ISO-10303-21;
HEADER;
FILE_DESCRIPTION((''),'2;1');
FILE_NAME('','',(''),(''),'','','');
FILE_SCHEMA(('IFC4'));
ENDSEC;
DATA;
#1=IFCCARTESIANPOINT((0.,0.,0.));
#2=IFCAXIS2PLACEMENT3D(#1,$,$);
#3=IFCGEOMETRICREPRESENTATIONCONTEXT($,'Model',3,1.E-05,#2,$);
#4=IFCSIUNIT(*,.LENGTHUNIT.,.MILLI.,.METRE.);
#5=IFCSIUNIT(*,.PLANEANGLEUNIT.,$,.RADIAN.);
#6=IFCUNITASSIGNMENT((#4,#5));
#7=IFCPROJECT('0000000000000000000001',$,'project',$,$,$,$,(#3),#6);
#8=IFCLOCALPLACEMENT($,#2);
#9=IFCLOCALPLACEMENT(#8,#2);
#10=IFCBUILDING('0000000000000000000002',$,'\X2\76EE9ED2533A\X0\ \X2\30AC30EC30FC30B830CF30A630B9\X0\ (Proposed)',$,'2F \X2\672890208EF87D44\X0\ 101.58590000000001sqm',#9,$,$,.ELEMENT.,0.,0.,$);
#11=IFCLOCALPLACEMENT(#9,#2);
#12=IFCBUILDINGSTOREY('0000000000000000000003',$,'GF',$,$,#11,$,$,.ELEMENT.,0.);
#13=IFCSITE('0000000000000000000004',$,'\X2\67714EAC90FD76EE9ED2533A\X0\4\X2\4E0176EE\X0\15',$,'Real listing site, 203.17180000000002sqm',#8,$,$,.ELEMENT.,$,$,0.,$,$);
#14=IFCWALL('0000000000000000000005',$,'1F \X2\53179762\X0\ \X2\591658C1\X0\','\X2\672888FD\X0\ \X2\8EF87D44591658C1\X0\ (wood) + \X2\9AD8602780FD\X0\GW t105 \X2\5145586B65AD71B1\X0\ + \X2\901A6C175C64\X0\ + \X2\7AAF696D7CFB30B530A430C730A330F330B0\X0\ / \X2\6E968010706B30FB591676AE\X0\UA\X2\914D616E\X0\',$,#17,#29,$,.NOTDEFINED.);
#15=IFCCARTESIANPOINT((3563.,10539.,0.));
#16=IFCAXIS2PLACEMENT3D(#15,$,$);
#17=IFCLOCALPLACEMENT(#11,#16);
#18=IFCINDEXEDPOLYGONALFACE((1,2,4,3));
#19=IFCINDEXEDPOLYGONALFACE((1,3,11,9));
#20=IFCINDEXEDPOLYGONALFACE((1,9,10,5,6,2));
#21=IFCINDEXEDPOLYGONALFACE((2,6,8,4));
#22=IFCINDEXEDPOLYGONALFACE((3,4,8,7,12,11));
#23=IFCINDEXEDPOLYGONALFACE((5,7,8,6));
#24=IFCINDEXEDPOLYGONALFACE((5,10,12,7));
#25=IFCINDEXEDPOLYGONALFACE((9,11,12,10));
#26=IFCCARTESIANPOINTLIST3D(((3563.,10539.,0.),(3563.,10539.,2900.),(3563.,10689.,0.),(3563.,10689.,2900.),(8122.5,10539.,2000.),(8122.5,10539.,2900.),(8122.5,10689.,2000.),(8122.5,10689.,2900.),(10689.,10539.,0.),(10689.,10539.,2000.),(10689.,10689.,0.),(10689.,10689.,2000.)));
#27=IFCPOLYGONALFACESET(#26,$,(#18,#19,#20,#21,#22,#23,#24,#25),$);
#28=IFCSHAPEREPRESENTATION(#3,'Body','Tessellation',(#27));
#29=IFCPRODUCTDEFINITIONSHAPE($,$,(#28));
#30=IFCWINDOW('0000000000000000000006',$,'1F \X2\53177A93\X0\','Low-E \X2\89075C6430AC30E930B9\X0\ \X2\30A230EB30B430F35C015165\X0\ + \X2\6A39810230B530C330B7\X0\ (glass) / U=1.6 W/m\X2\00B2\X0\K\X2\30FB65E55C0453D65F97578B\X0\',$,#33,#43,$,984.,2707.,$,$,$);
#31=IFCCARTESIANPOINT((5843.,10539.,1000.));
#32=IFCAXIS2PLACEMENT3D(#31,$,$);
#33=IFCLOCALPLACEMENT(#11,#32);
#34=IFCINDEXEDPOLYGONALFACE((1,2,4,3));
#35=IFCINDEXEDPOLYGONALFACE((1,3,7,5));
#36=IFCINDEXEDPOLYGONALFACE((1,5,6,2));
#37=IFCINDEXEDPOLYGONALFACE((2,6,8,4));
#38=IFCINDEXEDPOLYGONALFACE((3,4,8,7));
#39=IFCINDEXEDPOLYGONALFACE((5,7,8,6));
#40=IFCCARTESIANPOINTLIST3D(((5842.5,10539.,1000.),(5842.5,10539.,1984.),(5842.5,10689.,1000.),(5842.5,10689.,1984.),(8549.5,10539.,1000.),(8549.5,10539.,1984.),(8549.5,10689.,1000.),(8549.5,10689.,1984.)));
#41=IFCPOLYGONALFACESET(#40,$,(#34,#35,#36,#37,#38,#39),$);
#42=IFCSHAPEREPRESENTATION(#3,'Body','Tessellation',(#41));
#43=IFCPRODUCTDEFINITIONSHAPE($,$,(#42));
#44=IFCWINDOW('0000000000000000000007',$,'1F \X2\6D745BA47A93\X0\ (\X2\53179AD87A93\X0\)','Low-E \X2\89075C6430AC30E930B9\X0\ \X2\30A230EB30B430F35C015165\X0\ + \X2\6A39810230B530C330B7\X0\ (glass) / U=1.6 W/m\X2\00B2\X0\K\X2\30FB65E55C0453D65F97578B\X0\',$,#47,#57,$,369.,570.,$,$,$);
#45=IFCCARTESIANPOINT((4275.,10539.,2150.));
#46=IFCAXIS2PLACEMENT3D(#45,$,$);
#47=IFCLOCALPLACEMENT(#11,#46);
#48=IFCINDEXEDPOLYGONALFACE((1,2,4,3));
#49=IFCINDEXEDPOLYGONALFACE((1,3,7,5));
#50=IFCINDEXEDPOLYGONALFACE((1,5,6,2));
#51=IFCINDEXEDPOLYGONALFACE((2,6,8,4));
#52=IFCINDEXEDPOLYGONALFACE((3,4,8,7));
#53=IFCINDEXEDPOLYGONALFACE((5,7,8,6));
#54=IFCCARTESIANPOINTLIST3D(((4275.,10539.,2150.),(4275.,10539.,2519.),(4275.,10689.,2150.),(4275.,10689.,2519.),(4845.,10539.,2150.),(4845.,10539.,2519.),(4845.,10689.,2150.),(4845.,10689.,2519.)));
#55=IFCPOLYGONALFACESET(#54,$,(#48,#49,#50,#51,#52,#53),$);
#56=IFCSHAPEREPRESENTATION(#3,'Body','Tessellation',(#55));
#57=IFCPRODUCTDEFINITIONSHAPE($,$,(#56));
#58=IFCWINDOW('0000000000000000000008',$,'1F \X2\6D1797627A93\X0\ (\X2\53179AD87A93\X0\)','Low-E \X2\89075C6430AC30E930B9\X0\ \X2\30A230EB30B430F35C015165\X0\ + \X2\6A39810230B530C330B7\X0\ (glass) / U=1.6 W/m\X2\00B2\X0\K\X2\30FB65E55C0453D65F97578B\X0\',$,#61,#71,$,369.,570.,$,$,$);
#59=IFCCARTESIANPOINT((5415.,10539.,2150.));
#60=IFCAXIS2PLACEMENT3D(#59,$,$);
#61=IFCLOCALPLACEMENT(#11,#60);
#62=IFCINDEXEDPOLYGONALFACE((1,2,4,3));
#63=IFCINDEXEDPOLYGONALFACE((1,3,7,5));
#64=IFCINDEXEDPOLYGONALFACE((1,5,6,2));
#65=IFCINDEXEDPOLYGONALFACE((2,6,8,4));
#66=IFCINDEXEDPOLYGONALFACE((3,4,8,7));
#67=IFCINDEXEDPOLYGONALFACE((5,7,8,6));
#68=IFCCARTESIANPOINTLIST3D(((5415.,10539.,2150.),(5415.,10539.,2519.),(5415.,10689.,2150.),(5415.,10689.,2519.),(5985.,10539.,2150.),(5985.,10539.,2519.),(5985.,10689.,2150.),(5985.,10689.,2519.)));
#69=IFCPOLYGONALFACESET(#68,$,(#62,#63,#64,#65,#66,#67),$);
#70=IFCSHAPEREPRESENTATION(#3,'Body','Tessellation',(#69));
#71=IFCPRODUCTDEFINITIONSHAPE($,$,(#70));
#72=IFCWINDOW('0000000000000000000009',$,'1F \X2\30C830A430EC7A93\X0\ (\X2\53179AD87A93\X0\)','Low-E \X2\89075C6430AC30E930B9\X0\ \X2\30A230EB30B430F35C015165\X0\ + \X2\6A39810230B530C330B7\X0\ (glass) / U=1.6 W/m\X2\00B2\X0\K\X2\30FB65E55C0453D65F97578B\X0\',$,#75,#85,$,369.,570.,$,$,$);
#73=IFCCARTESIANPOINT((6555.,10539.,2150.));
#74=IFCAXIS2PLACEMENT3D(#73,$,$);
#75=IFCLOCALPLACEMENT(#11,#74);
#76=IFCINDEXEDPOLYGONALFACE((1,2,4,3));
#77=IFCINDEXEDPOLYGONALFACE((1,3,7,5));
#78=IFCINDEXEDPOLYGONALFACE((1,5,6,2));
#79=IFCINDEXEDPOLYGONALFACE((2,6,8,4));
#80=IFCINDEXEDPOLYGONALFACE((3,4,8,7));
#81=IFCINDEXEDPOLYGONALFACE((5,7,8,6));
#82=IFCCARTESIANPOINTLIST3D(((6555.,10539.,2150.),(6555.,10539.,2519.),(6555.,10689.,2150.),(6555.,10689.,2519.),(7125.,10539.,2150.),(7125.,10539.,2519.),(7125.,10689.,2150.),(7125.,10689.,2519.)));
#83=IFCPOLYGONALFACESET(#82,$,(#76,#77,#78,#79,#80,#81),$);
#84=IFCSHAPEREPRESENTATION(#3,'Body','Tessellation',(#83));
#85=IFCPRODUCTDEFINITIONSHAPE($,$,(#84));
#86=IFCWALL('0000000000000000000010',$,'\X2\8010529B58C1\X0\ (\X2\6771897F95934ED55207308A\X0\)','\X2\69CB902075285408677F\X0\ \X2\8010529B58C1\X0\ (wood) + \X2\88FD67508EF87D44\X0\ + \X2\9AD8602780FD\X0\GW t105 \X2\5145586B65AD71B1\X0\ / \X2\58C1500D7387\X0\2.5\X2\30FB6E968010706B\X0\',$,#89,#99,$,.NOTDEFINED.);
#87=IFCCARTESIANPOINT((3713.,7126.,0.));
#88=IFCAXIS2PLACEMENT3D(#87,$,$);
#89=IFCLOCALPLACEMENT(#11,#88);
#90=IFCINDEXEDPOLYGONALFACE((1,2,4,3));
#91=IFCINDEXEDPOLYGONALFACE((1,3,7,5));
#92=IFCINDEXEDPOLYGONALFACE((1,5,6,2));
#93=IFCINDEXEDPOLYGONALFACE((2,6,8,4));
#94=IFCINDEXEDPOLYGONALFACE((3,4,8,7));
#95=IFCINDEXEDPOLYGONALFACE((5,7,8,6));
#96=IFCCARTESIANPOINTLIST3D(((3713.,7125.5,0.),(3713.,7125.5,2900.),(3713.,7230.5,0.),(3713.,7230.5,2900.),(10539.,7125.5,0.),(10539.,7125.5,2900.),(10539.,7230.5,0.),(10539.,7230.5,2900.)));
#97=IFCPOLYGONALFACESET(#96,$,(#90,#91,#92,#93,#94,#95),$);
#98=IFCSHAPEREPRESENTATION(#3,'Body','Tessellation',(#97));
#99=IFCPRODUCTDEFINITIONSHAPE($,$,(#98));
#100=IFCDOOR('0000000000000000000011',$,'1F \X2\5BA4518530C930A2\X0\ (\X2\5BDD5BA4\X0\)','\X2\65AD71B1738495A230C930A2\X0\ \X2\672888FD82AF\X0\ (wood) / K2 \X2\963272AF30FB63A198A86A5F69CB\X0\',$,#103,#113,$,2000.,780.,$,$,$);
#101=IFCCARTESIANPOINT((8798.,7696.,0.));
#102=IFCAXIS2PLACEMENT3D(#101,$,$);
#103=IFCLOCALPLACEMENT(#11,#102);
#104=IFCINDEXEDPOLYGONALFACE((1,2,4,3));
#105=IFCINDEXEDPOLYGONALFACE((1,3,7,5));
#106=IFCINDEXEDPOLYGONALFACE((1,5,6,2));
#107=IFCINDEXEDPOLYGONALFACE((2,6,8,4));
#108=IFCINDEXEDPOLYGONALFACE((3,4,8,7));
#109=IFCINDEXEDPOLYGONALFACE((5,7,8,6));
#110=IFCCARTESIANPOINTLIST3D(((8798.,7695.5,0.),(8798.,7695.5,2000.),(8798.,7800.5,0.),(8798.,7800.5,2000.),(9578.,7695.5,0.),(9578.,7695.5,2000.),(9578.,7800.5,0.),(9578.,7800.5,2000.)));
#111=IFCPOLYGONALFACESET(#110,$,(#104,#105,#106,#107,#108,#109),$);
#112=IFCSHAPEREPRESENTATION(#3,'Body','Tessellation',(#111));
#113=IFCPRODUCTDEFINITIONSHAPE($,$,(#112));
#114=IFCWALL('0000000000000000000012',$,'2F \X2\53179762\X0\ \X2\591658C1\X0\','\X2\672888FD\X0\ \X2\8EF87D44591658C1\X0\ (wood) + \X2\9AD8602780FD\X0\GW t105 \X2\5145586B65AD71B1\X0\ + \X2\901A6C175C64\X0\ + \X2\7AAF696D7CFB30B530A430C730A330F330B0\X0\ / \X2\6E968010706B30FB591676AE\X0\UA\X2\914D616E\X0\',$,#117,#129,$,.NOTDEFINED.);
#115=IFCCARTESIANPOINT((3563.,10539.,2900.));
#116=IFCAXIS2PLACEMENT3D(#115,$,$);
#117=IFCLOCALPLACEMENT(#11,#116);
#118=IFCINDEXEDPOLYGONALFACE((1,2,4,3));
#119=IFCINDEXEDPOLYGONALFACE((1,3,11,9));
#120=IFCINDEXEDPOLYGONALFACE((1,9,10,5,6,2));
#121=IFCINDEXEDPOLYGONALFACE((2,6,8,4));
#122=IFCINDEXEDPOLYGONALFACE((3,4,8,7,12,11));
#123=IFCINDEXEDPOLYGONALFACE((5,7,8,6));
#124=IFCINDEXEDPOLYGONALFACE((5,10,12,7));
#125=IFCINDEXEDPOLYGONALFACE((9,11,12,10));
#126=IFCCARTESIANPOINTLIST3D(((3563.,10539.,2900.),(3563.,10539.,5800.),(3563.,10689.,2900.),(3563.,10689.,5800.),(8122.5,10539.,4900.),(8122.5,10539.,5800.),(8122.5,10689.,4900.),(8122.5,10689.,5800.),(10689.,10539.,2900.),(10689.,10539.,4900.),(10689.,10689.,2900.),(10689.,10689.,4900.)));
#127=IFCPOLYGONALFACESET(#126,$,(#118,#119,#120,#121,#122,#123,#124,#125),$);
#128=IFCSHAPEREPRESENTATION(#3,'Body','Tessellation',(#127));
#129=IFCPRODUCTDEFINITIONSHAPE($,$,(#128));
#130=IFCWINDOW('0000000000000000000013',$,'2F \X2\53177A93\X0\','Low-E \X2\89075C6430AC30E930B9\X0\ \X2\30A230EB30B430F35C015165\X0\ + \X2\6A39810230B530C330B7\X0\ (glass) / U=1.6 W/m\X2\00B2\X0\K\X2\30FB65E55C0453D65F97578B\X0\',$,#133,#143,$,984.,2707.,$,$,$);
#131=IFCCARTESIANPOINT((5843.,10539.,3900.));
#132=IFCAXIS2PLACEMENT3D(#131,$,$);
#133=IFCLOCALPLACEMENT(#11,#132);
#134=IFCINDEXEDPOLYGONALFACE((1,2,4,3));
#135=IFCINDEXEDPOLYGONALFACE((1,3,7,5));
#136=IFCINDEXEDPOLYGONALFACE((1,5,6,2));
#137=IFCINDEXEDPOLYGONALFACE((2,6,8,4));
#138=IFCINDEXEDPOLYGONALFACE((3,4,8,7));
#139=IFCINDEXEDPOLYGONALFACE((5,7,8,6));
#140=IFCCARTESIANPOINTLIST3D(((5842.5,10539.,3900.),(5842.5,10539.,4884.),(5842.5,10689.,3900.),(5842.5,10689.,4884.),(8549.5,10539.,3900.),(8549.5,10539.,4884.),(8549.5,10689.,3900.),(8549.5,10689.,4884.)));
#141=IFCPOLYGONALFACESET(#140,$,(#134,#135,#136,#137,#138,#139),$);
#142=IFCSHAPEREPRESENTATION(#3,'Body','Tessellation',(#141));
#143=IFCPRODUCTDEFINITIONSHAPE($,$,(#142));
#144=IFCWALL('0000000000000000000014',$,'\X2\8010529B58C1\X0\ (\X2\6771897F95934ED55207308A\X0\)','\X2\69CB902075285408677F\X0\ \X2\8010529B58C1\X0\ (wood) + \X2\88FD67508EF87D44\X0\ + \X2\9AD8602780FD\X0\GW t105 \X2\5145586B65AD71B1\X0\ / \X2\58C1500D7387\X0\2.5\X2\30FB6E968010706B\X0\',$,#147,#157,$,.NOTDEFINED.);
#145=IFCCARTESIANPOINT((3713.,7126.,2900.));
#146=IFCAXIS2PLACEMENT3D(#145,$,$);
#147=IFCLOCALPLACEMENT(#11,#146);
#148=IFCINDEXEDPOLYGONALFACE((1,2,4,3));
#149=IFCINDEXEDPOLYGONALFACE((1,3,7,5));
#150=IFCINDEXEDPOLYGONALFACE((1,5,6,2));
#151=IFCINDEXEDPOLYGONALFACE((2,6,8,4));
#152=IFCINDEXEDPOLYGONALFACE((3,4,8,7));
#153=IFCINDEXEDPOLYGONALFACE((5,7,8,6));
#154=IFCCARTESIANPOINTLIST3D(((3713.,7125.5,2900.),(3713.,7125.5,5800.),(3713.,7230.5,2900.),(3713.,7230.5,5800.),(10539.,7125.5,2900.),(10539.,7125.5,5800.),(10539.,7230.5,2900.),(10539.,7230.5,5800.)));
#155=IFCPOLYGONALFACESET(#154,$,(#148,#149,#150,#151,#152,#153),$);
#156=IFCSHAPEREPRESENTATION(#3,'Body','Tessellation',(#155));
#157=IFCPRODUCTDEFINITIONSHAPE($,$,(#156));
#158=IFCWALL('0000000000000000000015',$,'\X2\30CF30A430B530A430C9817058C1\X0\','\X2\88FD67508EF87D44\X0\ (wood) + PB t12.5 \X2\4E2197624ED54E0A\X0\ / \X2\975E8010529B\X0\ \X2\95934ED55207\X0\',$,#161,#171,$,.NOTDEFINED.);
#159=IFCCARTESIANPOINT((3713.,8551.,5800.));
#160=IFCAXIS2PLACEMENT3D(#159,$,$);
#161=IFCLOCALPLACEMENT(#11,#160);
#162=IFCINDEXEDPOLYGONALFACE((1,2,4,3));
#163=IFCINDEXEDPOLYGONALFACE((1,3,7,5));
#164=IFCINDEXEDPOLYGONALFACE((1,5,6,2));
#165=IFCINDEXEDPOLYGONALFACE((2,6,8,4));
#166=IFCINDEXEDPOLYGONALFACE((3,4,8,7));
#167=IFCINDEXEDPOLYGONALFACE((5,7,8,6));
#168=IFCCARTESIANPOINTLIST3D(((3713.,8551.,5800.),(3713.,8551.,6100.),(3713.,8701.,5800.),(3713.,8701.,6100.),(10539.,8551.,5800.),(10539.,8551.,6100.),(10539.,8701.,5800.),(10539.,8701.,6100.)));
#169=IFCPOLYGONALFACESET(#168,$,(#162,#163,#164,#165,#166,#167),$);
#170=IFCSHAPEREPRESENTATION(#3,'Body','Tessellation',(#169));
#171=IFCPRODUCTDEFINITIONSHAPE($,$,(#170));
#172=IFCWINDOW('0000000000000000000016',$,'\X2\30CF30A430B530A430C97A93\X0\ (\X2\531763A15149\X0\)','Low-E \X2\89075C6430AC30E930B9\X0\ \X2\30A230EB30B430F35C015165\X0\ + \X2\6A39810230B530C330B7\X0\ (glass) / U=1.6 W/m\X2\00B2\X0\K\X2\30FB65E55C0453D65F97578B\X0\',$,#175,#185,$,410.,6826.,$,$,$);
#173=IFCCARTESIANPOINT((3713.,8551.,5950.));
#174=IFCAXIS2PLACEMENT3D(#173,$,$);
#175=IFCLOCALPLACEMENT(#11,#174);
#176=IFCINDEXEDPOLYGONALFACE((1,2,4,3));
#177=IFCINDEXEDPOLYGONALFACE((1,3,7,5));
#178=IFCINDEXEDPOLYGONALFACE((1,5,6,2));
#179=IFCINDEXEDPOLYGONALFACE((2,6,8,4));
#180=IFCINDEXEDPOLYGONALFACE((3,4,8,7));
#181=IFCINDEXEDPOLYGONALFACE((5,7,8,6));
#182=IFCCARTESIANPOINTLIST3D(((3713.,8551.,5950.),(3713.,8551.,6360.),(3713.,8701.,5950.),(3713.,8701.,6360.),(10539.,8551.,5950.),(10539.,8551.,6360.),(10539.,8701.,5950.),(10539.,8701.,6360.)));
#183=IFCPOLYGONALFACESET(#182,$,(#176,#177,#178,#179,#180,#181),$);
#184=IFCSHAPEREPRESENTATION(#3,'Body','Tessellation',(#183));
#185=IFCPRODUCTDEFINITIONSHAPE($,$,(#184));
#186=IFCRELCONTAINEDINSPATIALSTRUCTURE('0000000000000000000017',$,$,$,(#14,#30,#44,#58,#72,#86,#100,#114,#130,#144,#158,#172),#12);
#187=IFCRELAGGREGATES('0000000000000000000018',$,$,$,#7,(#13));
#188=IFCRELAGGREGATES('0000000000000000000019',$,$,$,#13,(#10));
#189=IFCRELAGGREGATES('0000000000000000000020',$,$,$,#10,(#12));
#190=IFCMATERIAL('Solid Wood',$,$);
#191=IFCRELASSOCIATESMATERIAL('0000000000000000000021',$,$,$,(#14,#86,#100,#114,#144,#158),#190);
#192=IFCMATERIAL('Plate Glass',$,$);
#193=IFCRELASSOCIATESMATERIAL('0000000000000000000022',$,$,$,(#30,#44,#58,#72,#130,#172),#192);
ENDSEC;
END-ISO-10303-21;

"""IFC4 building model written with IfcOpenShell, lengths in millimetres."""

from ifc_helpers import new_model, si_unit, frame, frame_2d, origin, place, context, project, spatial, rectangle, extrude, material, element, fill, save


model = new_model("IFC4")

# Units and contexts
model_context = context("Model", 3, precision=1e-05, world=origin())
ifc_project = project(units=[si_unit("LENGTHUNIT", "METRE", prefix="MILLI"), si_unit("PLANEANGLEUNIT", "RADIAN")], contexts=[model_context])

# Site, building, storey
site_placement = place(None, origin())
site = spatial("IfcSite", under=ifc_project, at=site_placement, Name="東京都目黒区4丁目15", ObjectType="Real listing site, 203.17180000000002sqm", CompositionType="ELEMENT", RefElevation=0.0)
building_placement = place(site_placement, origin())
building = spatial("IfcBuilding", under=site, at=building_placement, Name="目黒区 ガレージハウス (Proposed)", ObjectType="2F 木造軸組 101.58590000000001sqm", CompositionType="ELEMENT", ElevationOfRefHeight=0.0, ElevationOfTerrain=0.0)
storey_placement = place(building_placement, origin())
storey = spatial("IfcBuildingStorey", under=building, at=storey_placement, Name="GF", CompositionType="ELEMENT", Elevation=0.0)

# Wall, openings, windows
ifc_material_1 = material(Name="Solid Wood")
wall_1_placement = place(storey_placement, frame((3563.0, 10539.0, 0.0)))
wall_1 = element("IfcWall", 1, at=wall_1_placement, inside=storey, material=ifc_material_1, Name="1F 北面 外壁", Description="木製 軸組外壁 (wood) + 高性能GW t105 充填断熱 + 通気層 + 窯業系サイディング / 準耐火・外皮UA配慮", PredefinedType="NOTDEFINED", context=model_context, shape_type="SweptSolid", body=[
    extrude(rectangle(XDim=7126.0, YDim=150.0, at=frame_2d((3563.0, 75.0))), frame((3563.0, 10539.0, 0.0)), (0.0, 0.0, 1.0), 2900.0),
])
opening_1_placement = place(storey_placement, frame((5843.0, 10539.0, 1000.0)))
opening_1 = element("IfcOpeningElement", 2, at=opening_1_placement, cuts=wall_1, PredefinedType="NOTDEFINED", context=model_context, shape_type="SweptSolid", body=[
    extrude(rectangle(XDim=2707.0, YDim=150.0, at=frame_2d((1353.0, 75.0))), frame((5843.0, 10539.0, 1000.0)), (0.0, 0.0, 1.0), 984.0),
])
opening_2_placement = place(storey_placement, frame((4275.0, 10539.0, 2150.0)))
opening_2 = element("IfcOpeningElement", 3, at=opening_2_placement, cuts=wall_1, PredefinedType="NOTDEFINED", context=model_context, shape_type="SweptSolid", body=[
    extrude(rectangle(XDim=570.0, YDim=150.0, at=frame_2d((285.0, 75.0))), frame((4275.0, 10539.0, 2150.0)), (0.0, 0.0, 1.0), 369.0),
])
opening_3_placement = place(storey_placement, frame((5415.0, 10539.0, 2150.0)))
opening_3 = element("IfcOpeningElement", 4, at=opening_3_placement, cuts=wall_1, PredefinedType="NOTDEFINED", context=model_context, shape_type="SweptSolid", body=[
    extrude(rectangle(XDim=570.0, YDim=150.0, at=frame_2d((285.0, 75.0))), frame((5415.0, 10539.0, 2150.0)), (0.0, 0.0, 1.0), 369.0),
])
opening_4_placement = place(storey_placement, frame((6555.0, 10539.0, 2150.0)))
opening_4 = element("IfcOpeningElement", 5, at=opening_4_placement, cuts=wall_1, PredefinedType="NOTDEFINED", context=model_context, shape_type="SweptSolid", body=[
    extrude(rectangle(XDim=570.0, YDim=150.0, at=frame_2d((285.0, 75.0))), frame((6555.0, 10539.0, 2150.0)), (0.0, 0.0, 1.0), 369.0),
])
ifc_material_2 = material(Name="Plate Glass")
window_1_placement = place(storey_placement, frame((5843.0, 10539.0, 1000.0)))
window_1 = element("IfcWindow", 6, at=window_1_placement, inside=storey, material=ifc_material_2, Name="1F 北窓", Description="Low-E 複層ガラス アルゴン封入 + 樹脂サッシ (glass) / U=1.6 W/m²K・日射取得型", OverallHeight=984.0, OverallWidth=2707.0, context=model_context, shape_type="SweptSolid", body=[
    extrude(rectangle(XDim=2707.0, YDim=150.0, at=frame_2d((1353.0, 75.0))), frame((5843.0, 10539.0, 1000.0)), (0.0, 0.0, 1.0), 984.0),
])
fill(opening_1, window_1)
window_2_placement = place(storey_placement, frame((4275.0, 10539.0, 2150.0)))
window_2 = element("IfcWindow", 7, at=window_2_placement, inside=storey, material=ifc_material_2, Name="1F 浴室窓 (北高窓)", Description="Low-E 複層ガラス アルゴン封入 + 樹脂サッシ (glass) / U=1.6 W/m²K・日射取得型", OverallHeight=369.0, OverallWidth=570.0, context=model_context, shape_type="SweptSolid", body=[
    extrude(rectangle(XDim=570.0, YDim=150.0, at=frame_2d((285.0, 75.0))), frame((4275.0, 10539.0, 2150.0)), (0.0, 0.0, 1.0), 369.0),
])
fill(opening_2, window_2)
window_3_placement = place(storey_placement, frame((5415.0, 10539.0, 2150.0)))
window_3 = element("IfcWindow", 8, at=window_3_placement, inside=storey, material=ifc_material_2, Name="1F 洗面窓 (北高窓)", Description="Low-E 複層ガラス アルゴン封入 + 樹脂サッシ (glass) / U=1.6 W/m²K・日射取得型", OverallHeight=369.0, OverallWidth=570.0, context=model_context, shape_type="SweptSolid", body=[
    extrude(rectangle(XDim=570.0, YDim=150.0, at=frame_2d((285.0, 75.0))), frame((5415.0, 10539.0, 2150.0)), (0.0, 0.0, 1.0), 369.0),
])
fill(opening_3, window_3)
window_4_placement = place(storey_placement, frame((6555.0, 10539.0, 2150.0)))
window_4 = element("IfcWindow", 9, at=window_4_placement, inside=storey, material=ifc_material_2, Name="1F トイレ窓 (北高窓)", Description="Low-E 複層ガラス アルゴン封入 + 樹脂サッシ (glass) / U=1.6 W/m²K・日射取得型", OverallHeight=369.0, OverallWidth=570.0, context=model_context, shape_type="SweptSolid", body=[
    extrude(rectangle(XDim=570.0, YDim=150.0, at=frame_2d((285.0, 75.0))), frame((6555.0, 10539.0, 2150.0)), (0.0, 0.0, 1.0), 369.0),
])
fill(opening_4, window_4)

# Wall
wall_2_placement = place(storey_placement, frame((3713.0, 7126.0, 0.0)))
element("IfcWall", 10, at=wall_2_placement, inside=storey, material=ifc_material_1, Name="耐力壁 (東西間仕切り)", Description="構造用合板 耐力壁 (wood) + 製材軸組 + 高性能GW t105 充填断熱 / 壁倍率2.5・準耐火", PredefinedType="NOTDEFINED", context=model_context, shape_type="SweptSolid", body=[
    extrude(rectangle(XDim=6826.0, YDim=105.0, at=frame_2d((3413.0, 52.0))), frame((3713.0, 7126.0, 0.0)), (0.0, 0.0, 1.0), 2900.0),
])

# Door
door_1_placement = place(storey_placement, frame((8798.0, 7696.0, 0.0)))
element("IfcDoor", 11, at=door_1_placement, inside=storey, material=ifc_material_1, Name="1F 室内ドア (寝室)", Description="断熱玄関ドア 木製芯 (wood) / K2 防犯・採風機構", OverallHeight=2000.0, OverallWidth=780.0, context=model_context, shape_type="SweptSolid", body=[
    extrude(rectangle(XDim=780.0, YDim=105.0, at=frame_2d((390.0, 52.0))), frame((8798.0, 7696.0, 0.0)), (0.0, 0.0, 1.0), 2000.0),
])

# Wall, opening, window
wall_3_placement = place(storey_placement, frame((3563.0, 10539.0, 2900.0)))
wall_3 = element("IfcWall", 12, at=wall_3_placement, inside=storey, material=ifc_material_1, Name="2F 北面 外壁", Description="木製 軸組外壁 (wood) + 高性能GW t105 充填断熱 + 通気層 + 窯業系サイディング / 準耐火・外皮UA配慮", PredefinedType="NOTDEFINED", context=model_context, shape_type="SweptSolid", body=[
    extrude(rectangle(XDim=7126.0, YDim=150.0, at=frame_2d((3563.0, 75.0))), frame((3563.0, 10539.0, 2900.0)), (0.0, 0.0, 1.0), 2900.0),
])
opening_5_placement = place(storey_placement, frame((5843.0, 10539.0, 3900.0)))
opening_5 = element("IfcOpeningElement", 13, at=opening_5_placement, cuts=wall_3, PredefinedType="NOTDEFINED", context=model_context, shape_type="SweptSolid", body=[
    extrude(rectangle(XDim=2707.0, YDim=150.0, at=frame_2d((1353.0, 75.0))), frame((5843.0, 10539.0, 3900.0)), (0.0, 0.0, 1.0), 984.0),
])
window_5_placement = place(storey_placement, frame((5843.0, 10539.0, 3900.0)))
window_5 = element("IfcWindow", 14, at=window_5_placement, inside=storey, material=ifc_material_2, Name="2F 北窓", Description="Low-E 複層ガラス アルゴン封入 + 樹脂サッシ (glass) / U=1.6 W/m²K・日射取得型", OverallHeight=984.0, OverallWidth=2707.0, context=model_context, shape_type="SweptSolid", body=[
    extrude(rectangle(XDim=2707.0, YDim=150.0, at=frame_2d((1353.0, 75.0))), frame((5843.0, 10539.0, 3900.0)), (0.0, 0.0, 1.0), 984.0),
])
fill(opening_5, window_5)

# Wall
wall_4_placement = place(storey_placement, frame((3713.0, 7126.0, 2900.0)))
element("IfcWall", 15, at=wall_4_placement, inside=storey, material=ifc_material_1, Name="耐力壁 (東西間仕切り)", Description="構造用合板 耐力壁 (wood) + 製材軸組 + 高性能GW t105 充填断熱 / 壁倍率2.5・準耐火", PredefinedType="NOTDEFINED", context=model_context, shape_type="SweptSolid", body=[
    extrude(rectangle(XDim=6826.0, YDim=105.0, at=frame_2d((3413.0, 52.0))), frame((3713.0, 7126.0, 2900.0)), (0.0, 0.0, 1.0), 2900.0),
])

# Wall, opening, window
wall_5_placement = place(storey_placement, frame((3713.0, 8551.0, 5800.0)))
wall_5 = element("IfcWall", 16, at=wall_5_placement, inside=storey, material=ifc_material_1, Name="ハイサイド腰壁", Description="製材軸組 (wood) + PB t12.5 両面仕上 / 非耐力 間仕切", PredefinedType="NOTDEFINED", context=model_context, shape_type="SweptSolid", body=[
    extrude(rectangle(XDim=6826.0, YDim=150.0, at=frame_2d((3413.0, 75.0))), frame((3713.0, 8551.0, 5800.0)), (0.0, 0.0, 1.0), 700.0),
])
opening_6_placement = place(storey_placement, frame((3713.0, 8551.0, 5950.0)))
opening_6 = element("IfcOpeningElement", 17, at=opening_6_placement, cuts=wall_5, PredefinedType="NOTDEFINED", context=model_context, shape_type="SweptSolid", body=[
    extrude(rectangle(XDim=6826.0, YDim=150.0, at=frame_2d((3413.0, 75.0))), frame((3713.0, 8551.0, 5950.0)), (0.0, 0.0, 1.0), 410.0),
])
window_6_placement = place(storey_placement, frame((3713.0, 8551.0, 5950.0)))
window_6 = element("IfcWindow", 18, at=window_6_placement, inside=storey, material=ifc_material_2, Name="ハイサイド窓 (北採光)", Description="Low-E 複層ガラス アルゴン封入 + 樹脂サッシ (glass) / U=1.6 W/m²K・日射取得型", OverallHeight=410.0, OverallWidth=6826.0, context=model_context, shape_type="SweptSolid", body=[
    extrude(rectangle(XDim=6826.0, YDim=150.0, at=frame_2d((3413.0, 75.0))), frame((3713.0, 8551.0, 5950.0)), (0.0, 0.0, 1.0), 410.0),
])
fill(opening_6, window_6)

save(model, "model.ifc")
